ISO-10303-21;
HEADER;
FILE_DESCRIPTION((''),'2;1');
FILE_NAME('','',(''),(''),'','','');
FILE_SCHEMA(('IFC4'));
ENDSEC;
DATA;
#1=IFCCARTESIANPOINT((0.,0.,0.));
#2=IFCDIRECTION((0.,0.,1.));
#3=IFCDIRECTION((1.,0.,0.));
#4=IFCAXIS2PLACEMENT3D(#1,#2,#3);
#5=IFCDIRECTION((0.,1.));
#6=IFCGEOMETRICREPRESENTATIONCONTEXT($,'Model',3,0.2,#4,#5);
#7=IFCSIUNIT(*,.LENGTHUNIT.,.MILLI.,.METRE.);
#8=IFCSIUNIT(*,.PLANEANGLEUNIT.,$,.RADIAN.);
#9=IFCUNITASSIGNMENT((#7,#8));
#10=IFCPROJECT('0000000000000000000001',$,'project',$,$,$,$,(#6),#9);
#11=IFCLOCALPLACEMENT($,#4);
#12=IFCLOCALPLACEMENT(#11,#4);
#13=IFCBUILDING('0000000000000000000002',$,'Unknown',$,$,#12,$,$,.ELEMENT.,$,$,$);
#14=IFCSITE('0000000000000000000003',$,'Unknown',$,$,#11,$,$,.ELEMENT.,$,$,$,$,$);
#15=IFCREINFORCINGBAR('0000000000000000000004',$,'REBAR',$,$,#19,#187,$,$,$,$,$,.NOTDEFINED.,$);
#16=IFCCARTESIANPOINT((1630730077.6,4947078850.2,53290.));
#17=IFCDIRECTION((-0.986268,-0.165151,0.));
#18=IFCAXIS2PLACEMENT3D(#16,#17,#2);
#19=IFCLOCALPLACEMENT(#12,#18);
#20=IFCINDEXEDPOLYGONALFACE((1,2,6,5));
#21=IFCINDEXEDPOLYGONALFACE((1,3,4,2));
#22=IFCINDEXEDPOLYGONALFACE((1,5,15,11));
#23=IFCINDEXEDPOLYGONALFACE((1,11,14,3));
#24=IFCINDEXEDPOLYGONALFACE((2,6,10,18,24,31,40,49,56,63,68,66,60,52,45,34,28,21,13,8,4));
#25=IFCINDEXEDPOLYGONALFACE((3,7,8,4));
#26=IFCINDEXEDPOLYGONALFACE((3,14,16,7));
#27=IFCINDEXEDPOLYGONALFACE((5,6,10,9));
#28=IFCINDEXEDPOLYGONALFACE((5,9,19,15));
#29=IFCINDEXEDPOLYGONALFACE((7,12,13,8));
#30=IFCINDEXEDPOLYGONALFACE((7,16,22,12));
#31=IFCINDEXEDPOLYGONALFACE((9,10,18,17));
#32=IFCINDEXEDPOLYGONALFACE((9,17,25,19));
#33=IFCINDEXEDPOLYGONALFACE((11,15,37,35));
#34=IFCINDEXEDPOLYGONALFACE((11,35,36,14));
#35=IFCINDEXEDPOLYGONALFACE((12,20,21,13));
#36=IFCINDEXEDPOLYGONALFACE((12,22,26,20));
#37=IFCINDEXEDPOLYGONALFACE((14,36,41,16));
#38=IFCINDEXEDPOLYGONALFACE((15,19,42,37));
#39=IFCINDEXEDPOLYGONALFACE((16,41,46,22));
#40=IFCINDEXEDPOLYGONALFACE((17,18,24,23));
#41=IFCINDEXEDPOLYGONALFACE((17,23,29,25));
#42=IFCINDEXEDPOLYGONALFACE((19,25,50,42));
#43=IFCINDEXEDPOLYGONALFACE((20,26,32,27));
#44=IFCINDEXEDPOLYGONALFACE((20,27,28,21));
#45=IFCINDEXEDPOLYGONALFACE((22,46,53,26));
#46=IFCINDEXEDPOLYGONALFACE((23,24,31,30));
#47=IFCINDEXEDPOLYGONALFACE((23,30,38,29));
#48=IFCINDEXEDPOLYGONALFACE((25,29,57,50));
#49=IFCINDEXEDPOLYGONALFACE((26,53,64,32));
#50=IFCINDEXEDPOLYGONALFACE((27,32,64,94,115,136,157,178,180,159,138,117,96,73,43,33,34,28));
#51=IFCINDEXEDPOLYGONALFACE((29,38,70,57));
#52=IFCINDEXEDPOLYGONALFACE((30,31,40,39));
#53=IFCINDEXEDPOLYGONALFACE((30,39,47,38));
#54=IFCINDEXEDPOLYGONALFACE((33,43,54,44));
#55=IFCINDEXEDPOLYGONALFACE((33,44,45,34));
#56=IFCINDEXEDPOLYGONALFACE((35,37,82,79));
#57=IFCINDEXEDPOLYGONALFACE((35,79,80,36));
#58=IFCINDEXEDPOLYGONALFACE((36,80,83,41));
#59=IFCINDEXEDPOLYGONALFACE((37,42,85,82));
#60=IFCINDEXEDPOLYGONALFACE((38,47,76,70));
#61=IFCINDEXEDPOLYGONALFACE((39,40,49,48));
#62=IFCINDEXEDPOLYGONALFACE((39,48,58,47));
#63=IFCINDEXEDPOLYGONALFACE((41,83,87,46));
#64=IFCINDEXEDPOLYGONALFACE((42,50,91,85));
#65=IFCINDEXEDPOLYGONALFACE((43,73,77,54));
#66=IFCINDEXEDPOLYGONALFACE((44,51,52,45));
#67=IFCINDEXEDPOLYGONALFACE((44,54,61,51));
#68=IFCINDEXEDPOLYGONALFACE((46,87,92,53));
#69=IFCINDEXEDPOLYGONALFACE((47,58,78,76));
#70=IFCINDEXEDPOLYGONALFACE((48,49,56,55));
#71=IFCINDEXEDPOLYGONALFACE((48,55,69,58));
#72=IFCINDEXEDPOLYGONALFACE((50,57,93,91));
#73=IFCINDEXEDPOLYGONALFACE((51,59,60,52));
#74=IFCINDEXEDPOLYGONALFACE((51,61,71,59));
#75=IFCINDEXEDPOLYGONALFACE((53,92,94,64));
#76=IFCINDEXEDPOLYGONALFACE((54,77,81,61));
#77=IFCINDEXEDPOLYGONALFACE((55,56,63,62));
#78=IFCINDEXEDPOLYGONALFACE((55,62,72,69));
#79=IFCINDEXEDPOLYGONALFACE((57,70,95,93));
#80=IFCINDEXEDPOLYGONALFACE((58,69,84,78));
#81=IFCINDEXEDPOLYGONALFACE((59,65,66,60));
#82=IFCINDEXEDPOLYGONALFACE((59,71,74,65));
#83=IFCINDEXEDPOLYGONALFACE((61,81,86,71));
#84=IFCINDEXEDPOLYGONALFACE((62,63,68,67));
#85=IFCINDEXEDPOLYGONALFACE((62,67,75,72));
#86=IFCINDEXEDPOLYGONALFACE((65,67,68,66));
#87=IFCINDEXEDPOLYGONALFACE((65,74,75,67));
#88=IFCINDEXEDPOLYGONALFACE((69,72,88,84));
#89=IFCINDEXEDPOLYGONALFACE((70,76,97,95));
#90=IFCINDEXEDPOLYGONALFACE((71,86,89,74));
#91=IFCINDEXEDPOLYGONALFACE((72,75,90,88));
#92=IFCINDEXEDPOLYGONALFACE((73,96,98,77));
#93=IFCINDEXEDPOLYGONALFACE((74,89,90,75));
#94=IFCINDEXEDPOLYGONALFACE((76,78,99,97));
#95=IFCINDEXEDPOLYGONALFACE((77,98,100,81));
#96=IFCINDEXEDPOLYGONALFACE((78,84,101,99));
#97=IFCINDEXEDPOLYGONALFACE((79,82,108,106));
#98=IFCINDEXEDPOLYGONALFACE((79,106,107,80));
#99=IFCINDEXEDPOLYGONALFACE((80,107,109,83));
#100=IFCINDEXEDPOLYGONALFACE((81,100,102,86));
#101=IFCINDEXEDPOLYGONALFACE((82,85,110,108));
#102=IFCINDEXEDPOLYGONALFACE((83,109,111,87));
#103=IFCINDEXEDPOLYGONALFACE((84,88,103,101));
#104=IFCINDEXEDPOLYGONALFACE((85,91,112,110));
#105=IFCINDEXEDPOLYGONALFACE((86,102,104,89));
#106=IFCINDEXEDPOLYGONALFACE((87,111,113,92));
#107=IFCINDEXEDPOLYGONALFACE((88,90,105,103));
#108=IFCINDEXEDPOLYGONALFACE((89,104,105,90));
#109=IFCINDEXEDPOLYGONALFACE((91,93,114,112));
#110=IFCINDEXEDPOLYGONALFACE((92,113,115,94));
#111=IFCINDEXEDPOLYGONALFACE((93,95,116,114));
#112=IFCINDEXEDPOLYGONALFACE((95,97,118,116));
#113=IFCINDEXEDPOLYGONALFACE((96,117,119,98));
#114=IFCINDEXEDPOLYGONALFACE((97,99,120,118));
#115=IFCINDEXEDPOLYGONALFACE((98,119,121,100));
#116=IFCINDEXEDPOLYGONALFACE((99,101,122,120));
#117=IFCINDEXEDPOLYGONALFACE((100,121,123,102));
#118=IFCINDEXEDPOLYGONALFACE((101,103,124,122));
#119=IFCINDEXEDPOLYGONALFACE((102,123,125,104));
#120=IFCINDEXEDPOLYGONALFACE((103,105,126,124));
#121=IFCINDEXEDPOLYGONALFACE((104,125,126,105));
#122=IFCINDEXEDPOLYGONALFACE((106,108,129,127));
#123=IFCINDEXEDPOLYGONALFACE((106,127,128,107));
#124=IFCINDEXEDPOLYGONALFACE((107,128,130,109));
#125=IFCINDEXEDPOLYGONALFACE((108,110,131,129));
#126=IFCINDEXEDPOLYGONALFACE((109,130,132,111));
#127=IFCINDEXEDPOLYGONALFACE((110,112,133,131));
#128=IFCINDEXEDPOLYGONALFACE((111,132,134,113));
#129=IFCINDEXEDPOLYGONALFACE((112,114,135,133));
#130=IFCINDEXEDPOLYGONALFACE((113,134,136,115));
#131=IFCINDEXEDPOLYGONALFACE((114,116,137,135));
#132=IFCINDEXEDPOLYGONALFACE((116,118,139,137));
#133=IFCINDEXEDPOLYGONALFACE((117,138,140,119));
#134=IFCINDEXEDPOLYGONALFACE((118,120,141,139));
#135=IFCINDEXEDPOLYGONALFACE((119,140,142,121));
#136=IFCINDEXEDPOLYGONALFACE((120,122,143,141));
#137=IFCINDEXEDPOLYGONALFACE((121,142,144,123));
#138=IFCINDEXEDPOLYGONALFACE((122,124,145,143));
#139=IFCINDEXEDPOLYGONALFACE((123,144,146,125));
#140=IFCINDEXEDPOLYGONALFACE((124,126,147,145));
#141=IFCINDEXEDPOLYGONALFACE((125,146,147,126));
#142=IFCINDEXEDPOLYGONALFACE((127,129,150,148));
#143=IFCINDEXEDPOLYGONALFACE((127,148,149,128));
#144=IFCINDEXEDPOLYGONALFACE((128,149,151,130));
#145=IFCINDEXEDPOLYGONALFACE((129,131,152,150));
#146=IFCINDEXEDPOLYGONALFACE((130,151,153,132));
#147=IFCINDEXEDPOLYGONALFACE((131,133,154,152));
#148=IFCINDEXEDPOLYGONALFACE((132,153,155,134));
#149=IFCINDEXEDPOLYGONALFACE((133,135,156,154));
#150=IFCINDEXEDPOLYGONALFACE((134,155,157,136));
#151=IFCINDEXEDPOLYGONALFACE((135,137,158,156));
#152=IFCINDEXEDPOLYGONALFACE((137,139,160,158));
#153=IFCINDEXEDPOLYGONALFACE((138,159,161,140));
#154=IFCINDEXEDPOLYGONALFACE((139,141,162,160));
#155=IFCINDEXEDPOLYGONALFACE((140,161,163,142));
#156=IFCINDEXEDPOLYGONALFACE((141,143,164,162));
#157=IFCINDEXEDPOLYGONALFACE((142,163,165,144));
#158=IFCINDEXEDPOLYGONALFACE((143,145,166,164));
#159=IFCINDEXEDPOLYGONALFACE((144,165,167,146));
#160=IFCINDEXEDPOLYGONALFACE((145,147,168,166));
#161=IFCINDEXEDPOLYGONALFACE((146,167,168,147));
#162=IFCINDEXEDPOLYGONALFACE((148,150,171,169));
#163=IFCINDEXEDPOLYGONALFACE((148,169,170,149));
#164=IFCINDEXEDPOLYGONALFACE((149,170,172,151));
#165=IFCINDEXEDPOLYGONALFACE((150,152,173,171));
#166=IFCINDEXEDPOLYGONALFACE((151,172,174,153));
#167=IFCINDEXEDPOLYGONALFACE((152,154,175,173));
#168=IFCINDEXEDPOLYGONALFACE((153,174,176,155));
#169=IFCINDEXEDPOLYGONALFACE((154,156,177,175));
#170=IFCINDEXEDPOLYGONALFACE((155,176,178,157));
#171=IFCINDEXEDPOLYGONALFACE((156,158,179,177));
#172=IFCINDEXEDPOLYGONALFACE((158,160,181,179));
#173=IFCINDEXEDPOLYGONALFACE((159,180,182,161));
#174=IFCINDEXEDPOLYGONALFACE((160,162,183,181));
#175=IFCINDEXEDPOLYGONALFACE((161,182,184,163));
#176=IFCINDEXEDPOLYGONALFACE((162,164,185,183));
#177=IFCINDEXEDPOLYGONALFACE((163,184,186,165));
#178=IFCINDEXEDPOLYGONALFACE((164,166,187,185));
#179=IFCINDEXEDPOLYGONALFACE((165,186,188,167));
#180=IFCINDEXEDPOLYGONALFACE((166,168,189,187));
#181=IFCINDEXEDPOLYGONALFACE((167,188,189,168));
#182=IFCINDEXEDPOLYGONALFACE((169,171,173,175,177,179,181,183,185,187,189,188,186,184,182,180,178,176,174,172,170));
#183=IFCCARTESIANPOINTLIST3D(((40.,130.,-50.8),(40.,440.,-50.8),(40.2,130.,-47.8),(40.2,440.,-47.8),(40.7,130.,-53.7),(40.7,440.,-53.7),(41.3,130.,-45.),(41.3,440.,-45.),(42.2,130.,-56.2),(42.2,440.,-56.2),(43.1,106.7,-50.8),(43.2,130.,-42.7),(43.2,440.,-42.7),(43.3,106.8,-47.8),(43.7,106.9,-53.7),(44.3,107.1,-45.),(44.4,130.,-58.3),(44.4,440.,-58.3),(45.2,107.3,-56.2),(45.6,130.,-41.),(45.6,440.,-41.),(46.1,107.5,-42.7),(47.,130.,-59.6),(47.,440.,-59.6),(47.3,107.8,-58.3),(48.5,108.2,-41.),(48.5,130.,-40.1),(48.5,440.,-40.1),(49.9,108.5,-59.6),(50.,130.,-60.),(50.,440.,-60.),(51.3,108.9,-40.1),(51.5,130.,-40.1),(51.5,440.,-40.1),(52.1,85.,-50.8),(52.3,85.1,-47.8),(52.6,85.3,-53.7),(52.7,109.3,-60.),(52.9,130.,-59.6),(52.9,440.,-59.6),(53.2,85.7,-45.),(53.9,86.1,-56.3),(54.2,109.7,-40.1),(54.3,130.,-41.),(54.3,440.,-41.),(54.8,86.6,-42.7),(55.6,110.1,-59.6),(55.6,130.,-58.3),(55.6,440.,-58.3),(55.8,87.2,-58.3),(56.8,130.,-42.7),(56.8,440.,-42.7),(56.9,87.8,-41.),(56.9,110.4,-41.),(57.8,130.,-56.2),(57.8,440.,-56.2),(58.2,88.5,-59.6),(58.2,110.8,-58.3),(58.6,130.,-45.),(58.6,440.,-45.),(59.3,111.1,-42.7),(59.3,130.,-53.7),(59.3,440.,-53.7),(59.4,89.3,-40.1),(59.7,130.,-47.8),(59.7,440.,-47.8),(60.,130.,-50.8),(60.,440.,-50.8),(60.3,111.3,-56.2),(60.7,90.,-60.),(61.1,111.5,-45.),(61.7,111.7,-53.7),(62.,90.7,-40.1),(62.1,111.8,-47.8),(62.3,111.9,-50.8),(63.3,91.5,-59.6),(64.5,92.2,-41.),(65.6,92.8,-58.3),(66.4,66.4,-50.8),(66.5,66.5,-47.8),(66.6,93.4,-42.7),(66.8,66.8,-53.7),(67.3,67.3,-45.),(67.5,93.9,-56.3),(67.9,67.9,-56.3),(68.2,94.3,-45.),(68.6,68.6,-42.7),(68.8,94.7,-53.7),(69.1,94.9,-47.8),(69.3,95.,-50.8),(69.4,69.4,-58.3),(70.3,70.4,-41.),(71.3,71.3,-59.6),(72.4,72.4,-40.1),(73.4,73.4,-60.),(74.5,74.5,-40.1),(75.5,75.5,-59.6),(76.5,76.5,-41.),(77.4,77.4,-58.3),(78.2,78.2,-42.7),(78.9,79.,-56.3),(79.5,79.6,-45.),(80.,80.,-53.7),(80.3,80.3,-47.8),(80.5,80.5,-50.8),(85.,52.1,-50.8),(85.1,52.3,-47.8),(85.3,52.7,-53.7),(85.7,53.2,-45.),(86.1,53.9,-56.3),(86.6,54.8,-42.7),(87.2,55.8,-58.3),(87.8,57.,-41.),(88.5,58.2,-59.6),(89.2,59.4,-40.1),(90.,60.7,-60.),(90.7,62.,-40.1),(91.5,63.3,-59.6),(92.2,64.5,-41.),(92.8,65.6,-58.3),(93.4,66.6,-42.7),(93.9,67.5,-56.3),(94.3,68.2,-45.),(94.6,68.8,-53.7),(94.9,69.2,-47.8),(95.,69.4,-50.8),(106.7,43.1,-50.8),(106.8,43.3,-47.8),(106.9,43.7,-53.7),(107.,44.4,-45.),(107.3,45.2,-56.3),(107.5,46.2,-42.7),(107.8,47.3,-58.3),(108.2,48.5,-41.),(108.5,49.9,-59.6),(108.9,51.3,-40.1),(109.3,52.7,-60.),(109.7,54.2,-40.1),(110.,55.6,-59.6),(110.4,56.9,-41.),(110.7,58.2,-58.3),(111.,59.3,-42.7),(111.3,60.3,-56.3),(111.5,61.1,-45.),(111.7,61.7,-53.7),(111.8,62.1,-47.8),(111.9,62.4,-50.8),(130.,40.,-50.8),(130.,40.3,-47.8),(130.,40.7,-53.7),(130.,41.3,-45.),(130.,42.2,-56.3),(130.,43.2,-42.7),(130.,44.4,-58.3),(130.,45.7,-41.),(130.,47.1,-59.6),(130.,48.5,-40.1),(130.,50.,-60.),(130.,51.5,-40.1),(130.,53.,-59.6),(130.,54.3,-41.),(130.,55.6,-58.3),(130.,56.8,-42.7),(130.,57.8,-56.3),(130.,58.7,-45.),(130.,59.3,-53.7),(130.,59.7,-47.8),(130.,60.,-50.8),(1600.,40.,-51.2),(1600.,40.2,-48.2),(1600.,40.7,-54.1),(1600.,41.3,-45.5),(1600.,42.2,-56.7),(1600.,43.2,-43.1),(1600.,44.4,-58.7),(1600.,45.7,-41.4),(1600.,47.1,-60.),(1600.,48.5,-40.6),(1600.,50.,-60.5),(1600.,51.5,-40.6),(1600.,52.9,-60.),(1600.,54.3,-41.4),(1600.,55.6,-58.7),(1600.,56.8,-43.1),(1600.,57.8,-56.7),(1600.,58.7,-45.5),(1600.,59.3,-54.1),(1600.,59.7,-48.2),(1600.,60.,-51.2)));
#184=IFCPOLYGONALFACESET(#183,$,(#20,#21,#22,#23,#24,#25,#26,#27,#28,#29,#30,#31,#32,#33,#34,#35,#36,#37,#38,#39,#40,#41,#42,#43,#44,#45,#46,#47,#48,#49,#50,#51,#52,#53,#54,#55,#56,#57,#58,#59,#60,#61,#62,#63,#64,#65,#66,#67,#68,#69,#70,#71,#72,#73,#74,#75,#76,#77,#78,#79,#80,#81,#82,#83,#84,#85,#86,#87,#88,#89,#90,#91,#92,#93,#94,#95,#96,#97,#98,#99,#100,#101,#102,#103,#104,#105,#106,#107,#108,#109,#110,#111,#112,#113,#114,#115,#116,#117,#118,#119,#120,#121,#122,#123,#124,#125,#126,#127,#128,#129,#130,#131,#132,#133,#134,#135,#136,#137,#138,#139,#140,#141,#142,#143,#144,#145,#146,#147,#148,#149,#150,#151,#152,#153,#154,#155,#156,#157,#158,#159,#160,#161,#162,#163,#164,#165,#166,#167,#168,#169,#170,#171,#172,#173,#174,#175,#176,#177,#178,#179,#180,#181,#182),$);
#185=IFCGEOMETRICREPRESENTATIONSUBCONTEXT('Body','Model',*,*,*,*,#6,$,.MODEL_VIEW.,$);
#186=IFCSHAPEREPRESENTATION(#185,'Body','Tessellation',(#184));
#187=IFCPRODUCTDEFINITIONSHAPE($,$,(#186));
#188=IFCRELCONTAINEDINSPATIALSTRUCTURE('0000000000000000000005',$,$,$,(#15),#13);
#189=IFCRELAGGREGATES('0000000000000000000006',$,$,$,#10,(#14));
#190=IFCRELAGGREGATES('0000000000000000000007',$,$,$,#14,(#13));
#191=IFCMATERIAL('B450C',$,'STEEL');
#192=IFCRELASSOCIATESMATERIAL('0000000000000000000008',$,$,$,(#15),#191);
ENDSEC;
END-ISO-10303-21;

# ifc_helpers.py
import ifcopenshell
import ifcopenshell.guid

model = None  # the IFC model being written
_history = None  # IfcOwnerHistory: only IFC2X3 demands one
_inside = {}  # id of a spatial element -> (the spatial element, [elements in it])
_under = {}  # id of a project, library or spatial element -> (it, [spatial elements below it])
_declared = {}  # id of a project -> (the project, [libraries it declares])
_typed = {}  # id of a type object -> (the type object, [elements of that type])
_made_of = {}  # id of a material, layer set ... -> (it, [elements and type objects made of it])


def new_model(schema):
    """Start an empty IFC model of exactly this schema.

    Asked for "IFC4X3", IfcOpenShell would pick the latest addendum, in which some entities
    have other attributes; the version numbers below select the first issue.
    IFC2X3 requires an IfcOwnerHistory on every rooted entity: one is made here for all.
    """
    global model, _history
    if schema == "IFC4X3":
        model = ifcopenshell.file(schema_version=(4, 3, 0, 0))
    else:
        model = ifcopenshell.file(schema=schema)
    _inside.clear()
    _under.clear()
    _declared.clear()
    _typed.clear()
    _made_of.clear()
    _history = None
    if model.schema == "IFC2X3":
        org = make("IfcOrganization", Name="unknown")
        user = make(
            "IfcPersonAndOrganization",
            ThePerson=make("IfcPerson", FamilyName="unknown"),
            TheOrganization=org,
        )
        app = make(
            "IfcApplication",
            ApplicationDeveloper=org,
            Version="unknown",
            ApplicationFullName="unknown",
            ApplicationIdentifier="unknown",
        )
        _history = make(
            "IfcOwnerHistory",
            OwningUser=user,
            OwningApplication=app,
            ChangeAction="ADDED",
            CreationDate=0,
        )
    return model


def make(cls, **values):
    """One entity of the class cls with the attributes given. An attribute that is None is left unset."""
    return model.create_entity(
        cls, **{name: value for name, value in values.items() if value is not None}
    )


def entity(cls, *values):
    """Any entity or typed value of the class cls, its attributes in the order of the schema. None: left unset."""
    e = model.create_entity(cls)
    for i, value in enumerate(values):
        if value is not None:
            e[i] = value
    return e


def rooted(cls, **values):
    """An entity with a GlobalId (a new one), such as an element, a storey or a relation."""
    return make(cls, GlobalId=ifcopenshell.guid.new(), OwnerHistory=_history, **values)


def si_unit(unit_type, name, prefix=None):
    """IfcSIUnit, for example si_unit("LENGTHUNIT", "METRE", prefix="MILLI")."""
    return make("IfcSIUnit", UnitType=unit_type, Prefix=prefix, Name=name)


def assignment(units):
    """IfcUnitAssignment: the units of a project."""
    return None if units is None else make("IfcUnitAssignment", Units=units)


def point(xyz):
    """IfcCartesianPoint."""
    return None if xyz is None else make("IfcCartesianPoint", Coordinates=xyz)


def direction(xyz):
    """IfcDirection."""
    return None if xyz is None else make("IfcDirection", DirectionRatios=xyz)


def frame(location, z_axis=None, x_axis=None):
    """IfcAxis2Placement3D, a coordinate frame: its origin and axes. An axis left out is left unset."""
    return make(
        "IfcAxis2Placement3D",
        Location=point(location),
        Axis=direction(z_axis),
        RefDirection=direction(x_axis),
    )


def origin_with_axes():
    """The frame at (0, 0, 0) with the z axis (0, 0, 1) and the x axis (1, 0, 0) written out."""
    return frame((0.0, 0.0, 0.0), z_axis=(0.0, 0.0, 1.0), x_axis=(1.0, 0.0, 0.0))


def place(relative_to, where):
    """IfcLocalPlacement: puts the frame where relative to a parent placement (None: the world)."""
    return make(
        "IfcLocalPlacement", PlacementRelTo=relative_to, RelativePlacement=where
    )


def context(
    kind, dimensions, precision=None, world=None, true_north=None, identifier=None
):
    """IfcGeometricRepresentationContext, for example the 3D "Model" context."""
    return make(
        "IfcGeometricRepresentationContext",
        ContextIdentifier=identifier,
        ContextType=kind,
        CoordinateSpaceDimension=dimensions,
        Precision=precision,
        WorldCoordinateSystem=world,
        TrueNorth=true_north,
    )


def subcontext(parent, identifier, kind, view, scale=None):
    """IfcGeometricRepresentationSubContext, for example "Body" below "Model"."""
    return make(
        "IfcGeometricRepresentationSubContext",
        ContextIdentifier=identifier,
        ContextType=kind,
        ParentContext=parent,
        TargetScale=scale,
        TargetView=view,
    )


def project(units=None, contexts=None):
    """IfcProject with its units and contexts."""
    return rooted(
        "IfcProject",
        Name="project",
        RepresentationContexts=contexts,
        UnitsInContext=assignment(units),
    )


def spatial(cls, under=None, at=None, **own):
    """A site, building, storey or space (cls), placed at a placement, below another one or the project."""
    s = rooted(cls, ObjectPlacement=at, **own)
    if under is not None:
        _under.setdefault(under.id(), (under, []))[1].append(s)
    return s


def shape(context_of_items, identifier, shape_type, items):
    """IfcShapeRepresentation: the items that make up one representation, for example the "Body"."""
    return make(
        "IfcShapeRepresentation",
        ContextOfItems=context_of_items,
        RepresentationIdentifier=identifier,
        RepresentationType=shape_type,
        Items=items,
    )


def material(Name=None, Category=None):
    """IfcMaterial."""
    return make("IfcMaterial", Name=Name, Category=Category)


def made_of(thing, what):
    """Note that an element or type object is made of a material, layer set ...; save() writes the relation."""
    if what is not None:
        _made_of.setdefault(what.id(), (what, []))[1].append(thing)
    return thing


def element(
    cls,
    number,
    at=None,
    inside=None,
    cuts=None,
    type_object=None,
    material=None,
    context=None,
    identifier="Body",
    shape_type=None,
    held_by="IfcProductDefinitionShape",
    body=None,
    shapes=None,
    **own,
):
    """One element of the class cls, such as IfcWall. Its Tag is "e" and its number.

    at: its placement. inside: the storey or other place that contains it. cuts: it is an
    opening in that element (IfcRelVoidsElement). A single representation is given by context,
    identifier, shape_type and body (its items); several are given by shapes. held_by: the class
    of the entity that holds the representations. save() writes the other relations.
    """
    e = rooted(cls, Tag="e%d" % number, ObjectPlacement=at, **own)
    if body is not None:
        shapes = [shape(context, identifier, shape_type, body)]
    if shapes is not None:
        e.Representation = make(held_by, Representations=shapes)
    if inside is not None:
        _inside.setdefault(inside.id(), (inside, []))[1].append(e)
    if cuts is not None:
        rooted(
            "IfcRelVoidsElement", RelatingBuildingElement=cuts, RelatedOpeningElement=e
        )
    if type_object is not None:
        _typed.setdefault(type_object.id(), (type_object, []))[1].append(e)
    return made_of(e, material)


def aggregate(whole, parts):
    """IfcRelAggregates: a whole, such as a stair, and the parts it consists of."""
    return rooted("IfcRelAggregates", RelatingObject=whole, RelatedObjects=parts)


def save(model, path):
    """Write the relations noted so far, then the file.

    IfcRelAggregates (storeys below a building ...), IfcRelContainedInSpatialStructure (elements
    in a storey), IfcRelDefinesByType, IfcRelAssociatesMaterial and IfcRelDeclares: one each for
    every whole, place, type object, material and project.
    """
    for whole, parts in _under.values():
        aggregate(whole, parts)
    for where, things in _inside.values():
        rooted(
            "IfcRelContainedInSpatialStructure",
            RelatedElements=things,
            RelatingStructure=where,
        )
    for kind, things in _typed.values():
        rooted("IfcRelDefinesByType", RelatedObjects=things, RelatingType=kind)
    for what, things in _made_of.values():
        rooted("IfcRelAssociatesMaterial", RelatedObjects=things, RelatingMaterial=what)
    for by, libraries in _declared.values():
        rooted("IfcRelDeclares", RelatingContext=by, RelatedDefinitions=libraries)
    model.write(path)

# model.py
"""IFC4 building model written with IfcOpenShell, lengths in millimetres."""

from ifc_helpers import new_model, entity, si_unit, direction, frame, origin_with_axes, place, context, subcontext, project, spatial, material, element, save


model = new_model("IFC4")

# Units and contexts
model_context = context("Model", 3, precision=0.2, world=origin_with_axes(), true_north=direction((0.0, 1.0)))
body_context = subcontext(model_context, "Body", "Model", "MODEL_VIEW")
ifc_project = project(units=[si_unit("LENGTHUNIT", "METRE", prefix="MILLI"), si_unit("PLANEANGLEUNIT", "RADIAN")], contexts=[model_context])

# Site, building
site_placement = place(None, origin_with_axes())
site = spatial("IfcSite", under=ifc_project, at=site_placement, Name="Unknown", CompositionType="ELEMENT")
building_placement = place(site_placement, origin_with_axes())
building = spatial("IfcBuilding", under=site, at=building_placement, Name="Unknown", CompositionType="ELEMENT")

# Reinforcing bar
ifc_material = material(Name="B450C", Category="STEEL")
reinforcing_bar_1_placement = place(building_placement, frame((1630730077.6, 4947078850.2, 53290.0), z_axis=(-0.986268, -0.165151, 0.0), x_axis=(0.0, 0.0, 1.0)))
element("IfcReinforcingBar", 1, at=reinforcing_bar_1_placement, inside=building, material=ifc_material, Name="REBAR", PredefinedType="NOTDEFINED", context=body_context, shape_type="AdvancedSweptSolid", body=[
    entity("IfcSweptDiskSolid", entity("IfcIndexedPolyCurve", entity("IfcCartesianPointList3D", [[50.0, 440.0, -50.0], [50.0, 130.0, -50.0], [73.4, 73.4, -50.0], [130.0, 50.0, -50.0], [1600.0, 50.0, -50.5]]), [entity("IfcLineIndex", [1, 2]), entity("IfcArcIndex", [2, 3, 4]), entity("IfcLineIndex", [4, 5])]), 10.0),
])

save(model, "model.ifc")
